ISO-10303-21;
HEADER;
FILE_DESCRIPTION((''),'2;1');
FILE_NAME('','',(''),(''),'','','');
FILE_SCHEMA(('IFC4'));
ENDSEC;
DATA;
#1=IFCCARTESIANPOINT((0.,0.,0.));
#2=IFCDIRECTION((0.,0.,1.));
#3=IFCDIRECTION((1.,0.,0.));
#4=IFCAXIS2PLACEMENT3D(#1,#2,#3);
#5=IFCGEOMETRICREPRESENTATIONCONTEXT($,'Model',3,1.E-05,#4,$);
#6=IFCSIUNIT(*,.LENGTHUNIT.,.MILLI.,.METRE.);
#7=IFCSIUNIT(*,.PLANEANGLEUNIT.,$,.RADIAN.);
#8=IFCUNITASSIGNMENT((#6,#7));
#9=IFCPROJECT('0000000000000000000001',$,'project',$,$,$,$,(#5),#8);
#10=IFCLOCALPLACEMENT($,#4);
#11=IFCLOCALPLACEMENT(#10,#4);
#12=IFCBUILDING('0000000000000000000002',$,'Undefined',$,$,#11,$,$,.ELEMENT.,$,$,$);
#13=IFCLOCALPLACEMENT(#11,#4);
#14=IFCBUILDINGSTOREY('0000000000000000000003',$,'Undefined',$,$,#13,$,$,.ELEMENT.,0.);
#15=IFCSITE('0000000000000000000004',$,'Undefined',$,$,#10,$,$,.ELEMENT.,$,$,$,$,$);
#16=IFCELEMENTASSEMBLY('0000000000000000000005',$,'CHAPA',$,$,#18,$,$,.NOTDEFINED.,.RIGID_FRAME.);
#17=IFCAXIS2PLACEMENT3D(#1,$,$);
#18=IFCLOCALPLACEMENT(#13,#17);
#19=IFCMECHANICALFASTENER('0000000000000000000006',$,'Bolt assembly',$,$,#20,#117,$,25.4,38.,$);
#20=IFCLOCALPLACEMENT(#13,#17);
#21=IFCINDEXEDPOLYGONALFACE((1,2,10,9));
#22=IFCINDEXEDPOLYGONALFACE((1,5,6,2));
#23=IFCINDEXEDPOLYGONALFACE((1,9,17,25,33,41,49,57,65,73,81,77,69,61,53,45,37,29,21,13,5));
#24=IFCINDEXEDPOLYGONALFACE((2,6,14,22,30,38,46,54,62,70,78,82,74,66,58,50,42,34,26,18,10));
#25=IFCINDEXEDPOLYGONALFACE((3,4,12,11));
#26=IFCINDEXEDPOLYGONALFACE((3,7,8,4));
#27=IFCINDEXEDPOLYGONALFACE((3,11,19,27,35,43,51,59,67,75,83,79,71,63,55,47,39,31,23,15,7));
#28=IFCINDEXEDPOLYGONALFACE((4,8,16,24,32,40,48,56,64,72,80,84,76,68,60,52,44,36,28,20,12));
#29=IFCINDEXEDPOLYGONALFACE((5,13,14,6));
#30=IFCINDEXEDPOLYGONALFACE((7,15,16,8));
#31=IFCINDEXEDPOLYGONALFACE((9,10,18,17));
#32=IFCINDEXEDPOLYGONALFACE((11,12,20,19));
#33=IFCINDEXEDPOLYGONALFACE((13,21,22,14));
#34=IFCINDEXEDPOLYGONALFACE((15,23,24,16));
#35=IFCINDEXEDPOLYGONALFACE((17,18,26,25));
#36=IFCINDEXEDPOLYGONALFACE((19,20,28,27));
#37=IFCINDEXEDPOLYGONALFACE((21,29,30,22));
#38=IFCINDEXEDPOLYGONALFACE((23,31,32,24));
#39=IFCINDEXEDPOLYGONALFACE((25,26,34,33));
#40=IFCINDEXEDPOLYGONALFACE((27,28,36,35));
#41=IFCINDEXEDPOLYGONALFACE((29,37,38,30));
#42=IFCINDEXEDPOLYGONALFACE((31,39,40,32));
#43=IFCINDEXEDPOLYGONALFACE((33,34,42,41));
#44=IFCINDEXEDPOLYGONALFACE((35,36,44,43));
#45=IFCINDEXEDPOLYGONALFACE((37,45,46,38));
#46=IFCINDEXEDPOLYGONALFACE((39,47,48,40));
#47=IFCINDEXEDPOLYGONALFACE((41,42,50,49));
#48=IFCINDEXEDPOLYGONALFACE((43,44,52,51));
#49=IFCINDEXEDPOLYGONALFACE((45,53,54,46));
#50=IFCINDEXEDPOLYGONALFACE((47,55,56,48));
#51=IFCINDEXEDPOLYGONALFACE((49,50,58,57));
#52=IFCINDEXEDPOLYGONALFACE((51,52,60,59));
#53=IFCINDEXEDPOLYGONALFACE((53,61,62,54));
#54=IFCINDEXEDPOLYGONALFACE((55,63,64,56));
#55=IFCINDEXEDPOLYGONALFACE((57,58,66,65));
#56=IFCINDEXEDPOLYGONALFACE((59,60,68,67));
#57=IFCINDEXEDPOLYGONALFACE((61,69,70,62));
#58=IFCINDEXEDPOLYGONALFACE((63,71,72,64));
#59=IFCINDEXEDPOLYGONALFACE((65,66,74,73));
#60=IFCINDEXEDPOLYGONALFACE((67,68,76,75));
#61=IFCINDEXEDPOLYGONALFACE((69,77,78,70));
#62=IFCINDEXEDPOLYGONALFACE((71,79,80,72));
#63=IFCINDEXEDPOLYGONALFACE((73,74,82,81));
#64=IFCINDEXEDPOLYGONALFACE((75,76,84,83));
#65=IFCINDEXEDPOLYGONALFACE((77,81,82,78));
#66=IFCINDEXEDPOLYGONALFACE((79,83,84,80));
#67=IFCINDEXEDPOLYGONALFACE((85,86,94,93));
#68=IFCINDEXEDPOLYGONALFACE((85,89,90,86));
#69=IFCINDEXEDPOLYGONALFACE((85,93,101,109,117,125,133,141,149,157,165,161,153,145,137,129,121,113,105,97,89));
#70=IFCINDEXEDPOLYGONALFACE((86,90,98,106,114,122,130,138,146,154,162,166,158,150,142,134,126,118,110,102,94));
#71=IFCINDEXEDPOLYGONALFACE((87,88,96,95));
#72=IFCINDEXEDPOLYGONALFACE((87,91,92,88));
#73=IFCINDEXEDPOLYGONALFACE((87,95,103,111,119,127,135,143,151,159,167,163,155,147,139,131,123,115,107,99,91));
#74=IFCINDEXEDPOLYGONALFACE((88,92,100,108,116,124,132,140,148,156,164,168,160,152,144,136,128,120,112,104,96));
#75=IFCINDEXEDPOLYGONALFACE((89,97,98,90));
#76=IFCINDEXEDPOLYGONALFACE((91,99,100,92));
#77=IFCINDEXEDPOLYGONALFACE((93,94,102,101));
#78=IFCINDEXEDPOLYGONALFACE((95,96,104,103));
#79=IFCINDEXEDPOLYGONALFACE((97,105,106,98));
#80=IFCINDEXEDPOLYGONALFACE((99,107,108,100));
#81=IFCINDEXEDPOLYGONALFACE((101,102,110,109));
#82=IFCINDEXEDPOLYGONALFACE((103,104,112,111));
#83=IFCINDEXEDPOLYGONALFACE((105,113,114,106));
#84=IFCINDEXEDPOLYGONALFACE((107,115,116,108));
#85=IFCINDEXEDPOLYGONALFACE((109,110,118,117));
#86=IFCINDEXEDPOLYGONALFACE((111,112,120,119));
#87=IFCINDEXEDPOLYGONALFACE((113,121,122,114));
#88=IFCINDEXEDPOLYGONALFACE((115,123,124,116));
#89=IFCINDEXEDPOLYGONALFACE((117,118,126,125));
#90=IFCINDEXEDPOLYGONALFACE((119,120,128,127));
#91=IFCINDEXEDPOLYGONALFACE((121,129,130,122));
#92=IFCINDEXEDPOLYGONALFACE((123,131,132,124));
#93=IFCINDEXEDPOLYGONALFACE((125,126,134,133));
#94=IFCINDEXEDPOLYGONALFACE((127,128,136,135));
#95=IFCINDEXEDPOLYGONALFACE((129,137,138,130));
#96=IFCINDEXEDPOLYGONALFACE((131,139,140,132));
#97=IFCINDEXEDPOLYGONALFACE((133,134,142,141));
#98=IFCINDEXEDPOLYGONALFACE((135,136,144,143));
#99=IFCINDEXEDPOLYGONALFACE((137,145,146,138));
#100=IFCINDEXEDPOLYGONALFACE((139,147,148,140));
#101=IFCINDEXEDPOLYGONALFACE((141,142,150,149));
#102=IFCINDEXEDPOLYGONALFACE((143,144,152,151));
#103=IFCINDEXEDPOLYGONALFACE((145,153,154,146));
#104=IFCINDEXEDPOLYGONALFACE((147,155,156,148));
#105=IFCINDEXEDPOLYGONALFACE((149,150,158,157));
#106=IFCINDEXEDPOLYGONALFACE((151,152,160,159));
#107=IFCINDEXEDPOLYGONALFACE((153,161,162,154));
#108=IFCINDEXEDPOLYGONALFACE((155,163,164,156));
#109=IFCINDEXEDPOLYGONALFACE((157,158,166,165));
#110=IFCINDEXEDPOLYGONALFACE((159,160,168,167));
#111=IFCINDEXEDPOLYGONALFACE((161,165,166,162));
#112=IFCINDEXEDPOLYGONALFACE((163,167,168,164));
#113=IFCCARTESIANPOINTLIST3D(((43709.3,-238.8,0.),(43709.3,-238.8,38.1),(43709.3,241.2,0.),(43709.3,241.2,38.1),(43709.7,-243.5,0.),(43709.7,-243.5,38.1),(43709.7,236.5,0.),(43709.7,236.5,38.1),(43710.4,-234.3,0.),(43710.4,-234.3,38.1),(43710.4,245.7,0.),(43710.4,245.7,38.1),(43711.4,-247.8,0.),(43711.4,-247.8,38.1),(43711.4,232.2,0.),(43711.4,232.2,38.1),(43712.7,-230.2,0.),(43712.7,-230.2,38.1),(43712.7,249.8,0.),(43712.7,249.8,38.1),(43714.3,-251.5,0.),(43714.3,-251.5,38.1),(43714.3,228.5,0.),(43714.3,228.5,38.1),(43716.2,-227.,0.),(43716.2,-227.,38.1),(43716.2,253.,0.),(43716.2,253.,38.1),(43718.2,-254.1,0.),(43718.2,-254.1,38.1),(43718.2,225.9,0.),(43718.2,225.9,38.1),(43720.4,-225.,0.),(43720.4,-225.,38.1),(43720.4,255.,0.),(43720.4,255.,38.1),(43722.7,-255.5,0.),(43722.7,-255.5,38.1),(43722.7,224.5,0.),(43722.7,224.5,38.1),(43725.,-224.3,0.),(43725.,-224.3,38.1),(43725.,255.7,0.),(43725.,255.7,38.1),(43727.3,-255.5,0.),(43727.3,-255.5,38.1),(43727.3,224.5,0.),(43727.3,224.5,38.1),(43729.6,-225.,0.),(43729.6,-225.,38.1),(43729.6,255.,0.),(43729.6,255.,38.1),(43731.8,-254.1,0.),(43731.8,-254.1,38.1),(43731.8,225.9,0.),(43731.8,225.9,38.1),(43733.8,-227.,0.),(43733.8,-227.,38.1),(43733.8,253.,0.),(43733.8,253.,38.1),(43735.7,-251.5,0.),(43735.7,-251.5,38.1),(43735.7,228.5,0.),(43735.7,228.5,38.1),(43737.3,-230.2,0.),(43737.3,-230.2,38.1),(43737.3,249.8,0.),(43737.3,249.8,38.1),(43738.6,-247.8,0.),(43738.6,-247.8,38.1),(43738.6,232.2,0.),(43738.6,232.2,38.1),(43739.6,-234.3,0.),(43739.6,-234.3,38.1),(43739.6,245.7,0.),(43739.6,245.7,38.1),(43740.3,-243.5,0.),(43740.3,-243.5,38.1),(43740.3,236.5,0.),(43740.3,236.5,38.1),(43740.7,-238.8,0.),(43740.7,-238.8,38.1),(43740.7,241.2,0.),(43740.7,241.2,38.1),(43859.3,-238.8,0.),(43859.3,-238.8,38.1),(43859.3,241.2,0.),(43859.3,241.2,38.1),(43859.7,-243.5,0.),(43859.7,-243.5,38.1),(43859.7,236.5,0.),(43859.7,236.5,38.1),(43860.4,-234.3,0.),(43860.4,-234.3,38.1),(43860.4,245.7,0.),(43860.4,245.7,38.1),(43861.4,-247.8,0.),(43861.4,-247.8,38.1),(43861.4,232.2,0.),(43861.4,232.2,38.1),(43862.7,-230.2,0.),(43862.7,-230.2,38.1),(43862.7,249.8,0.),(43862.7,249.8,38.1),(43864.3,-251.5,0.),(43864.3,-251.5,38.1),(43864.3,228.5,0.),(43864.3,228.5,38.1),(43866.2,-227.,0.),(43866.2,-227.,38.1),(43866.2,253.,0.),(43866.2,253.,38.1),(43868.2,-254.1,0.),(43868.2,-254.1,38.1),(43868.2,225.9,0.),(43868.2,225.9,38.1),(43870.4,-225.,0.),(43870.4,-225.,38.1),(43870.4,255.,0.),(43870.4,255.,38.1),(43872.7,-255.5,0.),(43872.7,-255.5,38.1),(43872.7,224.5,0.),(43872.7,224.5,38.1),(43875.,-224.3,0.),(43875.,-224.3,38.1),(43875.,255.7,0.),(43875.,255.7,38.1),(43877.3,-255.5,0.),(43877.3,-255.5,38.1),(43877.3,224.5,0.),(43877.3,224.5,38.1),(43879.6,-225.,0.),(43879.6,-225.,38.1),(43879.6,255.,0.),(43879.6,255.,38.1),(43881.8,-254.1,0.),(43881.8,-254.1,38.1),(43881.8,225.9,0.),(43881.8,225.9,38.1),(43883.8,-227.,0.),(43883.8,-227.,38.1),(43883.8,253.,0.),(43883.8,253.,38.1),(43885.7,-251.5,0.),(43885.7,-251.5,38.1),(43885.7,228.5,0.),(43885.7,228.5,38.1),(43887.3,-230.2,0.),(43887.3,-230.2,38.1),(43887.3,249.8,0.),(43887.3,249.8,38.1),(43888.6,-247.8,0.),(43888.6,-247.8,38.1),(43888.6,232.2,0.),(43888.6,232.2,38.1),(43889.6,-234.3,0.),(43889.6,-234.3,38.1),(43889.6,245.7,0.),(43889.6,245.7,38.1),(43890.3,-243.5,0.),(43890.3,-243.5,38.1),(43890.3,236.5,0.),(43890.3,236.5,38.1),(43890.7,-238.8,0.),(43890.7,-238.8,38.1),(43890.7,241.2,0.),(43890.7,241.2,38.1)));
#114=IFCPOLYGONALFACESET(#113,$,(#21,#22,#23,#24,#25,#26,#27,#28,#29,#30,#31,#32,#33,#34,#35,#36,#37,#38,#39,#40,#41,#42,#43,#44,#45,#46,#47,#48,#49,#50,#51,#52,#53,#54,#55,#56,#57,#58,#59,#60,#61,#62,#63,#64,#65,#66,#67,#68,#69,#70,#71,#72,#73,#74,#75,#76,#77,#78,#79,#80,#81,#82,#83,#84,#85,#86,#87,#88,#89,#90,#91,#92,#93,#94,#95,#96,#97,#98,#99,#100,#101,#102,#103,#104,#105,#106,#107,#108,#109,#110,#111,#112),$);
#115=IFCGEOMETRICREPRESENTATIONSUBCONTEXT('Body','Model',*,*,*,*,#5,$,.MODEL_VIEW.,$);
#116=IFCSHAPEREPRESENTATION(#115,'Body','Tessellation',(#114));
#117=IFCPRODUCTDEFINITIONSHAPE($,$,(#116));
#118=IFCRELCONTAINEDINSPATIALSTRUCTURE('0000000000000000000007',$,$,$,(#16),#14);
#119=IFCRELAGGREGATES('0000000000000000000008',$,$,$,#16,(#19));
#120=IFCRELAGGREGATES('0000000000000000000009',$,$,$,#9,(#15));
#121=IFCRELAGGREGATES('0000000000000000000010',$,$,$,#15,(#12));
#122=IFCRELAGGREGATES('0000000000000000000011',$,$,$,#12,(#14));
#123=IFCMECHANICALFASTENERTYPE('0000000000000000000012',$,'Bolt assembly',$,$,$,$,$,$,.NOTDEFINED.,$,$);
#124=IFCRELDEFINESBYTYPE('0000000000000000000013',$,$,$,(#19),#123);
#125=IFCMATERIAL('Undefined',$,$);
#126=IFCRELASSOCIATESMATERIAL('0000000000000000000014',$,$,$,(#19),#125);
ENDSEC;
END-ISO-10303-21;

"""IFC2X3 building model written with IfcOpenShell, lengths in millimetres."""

from ifc_helpers import new_model, si_unit, frame, origin_with_axes, origin_2d_with_axis, place, context, subcontext, project, spatial, circle, extrude, source, transform, mapped, material, type_object, element, aggregate, save


model = new_model("IFC2X3")

# Units and contexts
model_context = context("Model", 3, precision=1e-05, world=origin_with_axes())
body_context = subcontext(model_context, "Body", "Model", "MODEL_VIEW")
ifc_project = project(units=[si_unit("LENGTHUNIT", "METRE", prefix="MILLI"), si_unit("PLANEANGLEUNIT", "RADIAN")], contexts=[model_context])

# Site, building, storey
site_placement = place(None, origin_with_axes())
site = spatial("IfcSite", under=ifc_project, at=site_placement, Name="Undefined", CompositionType="ELEMENT")
building_placement = place(site_placement, origin_with_axes())
building = spatial("IfcBuilding", under=site, at=building_placement, Name="Undefined", CompositionType="ELEMENT")
storey_placement = place(building_placement, origin_with_axes())
storey = spatial("IfcBuildingStorey", under=building, at=storey_placement, Name="Undefined", CompositionType="ELEMENT", Elevation=0.0)

# Element assembly
assembly_1_placement = place(storey_placement, origin_with_axes())
assembly_1 = element("IfcElementAssembly", 1, at=assembly_1_placement, inside=storey, Name="CHAPA", AssemblyPlace="NOTDEFINED", PredefinedType="RIGID_FRAME")

# Shared definitions
ifc_material_1 = material(Name="Undefined")
mechanical_fastener_type = type_object("IfcMechanicalFastenerType", Name="Bolt assembly")

# Mechanical fastener
shared_shape_1 = source(origin_with_axes(), body_context, "Body", "SweptSolid", [
    extrude(circle(Radius=15.7, at=origin_2d_with_axis()), frame((0.0, -38.0, 0.0), z_axis=(0.0, 1.0, 0.0), x_axis=(1.0, 0.0, 0.0)), (0.0, 0.0, 1.0), 38.1),
])
mechanical_fastener_1_placement = place(assembly_1_placement, frame((43800.0, -240.0, 38.0), z_axis=(1.0, 0.0, 0.0), x_axis=(0.0, 1.0, 0.0)))
mechanical_fastener_1 = element("IfcMechanicalFastener", 2, at=mechanical_fastener_1_placement, type_object=mechanical_fastener_type, material=ifc_material_1, Name="Bolt assembly", NominalDiameter=25.4, NominalLength=38.0, context=body_context, shape_type="MappedRepresentation", body=[
    mapped(shared_shape_1, transform((0.0, 0.0, -75.0))),
    mapped(shared_shape_1, transform((0.0, 0.0, 75.0))),
    mapped(shared_shape_1, transform((480.0, 0.0, -75.0))),
    mapped(shared_shape_1, transform((480.0, 0.0, 75.0))),
])
aggregate(assembly_1, [mechanical_fastener_1])

save(model, "model.ifc")
